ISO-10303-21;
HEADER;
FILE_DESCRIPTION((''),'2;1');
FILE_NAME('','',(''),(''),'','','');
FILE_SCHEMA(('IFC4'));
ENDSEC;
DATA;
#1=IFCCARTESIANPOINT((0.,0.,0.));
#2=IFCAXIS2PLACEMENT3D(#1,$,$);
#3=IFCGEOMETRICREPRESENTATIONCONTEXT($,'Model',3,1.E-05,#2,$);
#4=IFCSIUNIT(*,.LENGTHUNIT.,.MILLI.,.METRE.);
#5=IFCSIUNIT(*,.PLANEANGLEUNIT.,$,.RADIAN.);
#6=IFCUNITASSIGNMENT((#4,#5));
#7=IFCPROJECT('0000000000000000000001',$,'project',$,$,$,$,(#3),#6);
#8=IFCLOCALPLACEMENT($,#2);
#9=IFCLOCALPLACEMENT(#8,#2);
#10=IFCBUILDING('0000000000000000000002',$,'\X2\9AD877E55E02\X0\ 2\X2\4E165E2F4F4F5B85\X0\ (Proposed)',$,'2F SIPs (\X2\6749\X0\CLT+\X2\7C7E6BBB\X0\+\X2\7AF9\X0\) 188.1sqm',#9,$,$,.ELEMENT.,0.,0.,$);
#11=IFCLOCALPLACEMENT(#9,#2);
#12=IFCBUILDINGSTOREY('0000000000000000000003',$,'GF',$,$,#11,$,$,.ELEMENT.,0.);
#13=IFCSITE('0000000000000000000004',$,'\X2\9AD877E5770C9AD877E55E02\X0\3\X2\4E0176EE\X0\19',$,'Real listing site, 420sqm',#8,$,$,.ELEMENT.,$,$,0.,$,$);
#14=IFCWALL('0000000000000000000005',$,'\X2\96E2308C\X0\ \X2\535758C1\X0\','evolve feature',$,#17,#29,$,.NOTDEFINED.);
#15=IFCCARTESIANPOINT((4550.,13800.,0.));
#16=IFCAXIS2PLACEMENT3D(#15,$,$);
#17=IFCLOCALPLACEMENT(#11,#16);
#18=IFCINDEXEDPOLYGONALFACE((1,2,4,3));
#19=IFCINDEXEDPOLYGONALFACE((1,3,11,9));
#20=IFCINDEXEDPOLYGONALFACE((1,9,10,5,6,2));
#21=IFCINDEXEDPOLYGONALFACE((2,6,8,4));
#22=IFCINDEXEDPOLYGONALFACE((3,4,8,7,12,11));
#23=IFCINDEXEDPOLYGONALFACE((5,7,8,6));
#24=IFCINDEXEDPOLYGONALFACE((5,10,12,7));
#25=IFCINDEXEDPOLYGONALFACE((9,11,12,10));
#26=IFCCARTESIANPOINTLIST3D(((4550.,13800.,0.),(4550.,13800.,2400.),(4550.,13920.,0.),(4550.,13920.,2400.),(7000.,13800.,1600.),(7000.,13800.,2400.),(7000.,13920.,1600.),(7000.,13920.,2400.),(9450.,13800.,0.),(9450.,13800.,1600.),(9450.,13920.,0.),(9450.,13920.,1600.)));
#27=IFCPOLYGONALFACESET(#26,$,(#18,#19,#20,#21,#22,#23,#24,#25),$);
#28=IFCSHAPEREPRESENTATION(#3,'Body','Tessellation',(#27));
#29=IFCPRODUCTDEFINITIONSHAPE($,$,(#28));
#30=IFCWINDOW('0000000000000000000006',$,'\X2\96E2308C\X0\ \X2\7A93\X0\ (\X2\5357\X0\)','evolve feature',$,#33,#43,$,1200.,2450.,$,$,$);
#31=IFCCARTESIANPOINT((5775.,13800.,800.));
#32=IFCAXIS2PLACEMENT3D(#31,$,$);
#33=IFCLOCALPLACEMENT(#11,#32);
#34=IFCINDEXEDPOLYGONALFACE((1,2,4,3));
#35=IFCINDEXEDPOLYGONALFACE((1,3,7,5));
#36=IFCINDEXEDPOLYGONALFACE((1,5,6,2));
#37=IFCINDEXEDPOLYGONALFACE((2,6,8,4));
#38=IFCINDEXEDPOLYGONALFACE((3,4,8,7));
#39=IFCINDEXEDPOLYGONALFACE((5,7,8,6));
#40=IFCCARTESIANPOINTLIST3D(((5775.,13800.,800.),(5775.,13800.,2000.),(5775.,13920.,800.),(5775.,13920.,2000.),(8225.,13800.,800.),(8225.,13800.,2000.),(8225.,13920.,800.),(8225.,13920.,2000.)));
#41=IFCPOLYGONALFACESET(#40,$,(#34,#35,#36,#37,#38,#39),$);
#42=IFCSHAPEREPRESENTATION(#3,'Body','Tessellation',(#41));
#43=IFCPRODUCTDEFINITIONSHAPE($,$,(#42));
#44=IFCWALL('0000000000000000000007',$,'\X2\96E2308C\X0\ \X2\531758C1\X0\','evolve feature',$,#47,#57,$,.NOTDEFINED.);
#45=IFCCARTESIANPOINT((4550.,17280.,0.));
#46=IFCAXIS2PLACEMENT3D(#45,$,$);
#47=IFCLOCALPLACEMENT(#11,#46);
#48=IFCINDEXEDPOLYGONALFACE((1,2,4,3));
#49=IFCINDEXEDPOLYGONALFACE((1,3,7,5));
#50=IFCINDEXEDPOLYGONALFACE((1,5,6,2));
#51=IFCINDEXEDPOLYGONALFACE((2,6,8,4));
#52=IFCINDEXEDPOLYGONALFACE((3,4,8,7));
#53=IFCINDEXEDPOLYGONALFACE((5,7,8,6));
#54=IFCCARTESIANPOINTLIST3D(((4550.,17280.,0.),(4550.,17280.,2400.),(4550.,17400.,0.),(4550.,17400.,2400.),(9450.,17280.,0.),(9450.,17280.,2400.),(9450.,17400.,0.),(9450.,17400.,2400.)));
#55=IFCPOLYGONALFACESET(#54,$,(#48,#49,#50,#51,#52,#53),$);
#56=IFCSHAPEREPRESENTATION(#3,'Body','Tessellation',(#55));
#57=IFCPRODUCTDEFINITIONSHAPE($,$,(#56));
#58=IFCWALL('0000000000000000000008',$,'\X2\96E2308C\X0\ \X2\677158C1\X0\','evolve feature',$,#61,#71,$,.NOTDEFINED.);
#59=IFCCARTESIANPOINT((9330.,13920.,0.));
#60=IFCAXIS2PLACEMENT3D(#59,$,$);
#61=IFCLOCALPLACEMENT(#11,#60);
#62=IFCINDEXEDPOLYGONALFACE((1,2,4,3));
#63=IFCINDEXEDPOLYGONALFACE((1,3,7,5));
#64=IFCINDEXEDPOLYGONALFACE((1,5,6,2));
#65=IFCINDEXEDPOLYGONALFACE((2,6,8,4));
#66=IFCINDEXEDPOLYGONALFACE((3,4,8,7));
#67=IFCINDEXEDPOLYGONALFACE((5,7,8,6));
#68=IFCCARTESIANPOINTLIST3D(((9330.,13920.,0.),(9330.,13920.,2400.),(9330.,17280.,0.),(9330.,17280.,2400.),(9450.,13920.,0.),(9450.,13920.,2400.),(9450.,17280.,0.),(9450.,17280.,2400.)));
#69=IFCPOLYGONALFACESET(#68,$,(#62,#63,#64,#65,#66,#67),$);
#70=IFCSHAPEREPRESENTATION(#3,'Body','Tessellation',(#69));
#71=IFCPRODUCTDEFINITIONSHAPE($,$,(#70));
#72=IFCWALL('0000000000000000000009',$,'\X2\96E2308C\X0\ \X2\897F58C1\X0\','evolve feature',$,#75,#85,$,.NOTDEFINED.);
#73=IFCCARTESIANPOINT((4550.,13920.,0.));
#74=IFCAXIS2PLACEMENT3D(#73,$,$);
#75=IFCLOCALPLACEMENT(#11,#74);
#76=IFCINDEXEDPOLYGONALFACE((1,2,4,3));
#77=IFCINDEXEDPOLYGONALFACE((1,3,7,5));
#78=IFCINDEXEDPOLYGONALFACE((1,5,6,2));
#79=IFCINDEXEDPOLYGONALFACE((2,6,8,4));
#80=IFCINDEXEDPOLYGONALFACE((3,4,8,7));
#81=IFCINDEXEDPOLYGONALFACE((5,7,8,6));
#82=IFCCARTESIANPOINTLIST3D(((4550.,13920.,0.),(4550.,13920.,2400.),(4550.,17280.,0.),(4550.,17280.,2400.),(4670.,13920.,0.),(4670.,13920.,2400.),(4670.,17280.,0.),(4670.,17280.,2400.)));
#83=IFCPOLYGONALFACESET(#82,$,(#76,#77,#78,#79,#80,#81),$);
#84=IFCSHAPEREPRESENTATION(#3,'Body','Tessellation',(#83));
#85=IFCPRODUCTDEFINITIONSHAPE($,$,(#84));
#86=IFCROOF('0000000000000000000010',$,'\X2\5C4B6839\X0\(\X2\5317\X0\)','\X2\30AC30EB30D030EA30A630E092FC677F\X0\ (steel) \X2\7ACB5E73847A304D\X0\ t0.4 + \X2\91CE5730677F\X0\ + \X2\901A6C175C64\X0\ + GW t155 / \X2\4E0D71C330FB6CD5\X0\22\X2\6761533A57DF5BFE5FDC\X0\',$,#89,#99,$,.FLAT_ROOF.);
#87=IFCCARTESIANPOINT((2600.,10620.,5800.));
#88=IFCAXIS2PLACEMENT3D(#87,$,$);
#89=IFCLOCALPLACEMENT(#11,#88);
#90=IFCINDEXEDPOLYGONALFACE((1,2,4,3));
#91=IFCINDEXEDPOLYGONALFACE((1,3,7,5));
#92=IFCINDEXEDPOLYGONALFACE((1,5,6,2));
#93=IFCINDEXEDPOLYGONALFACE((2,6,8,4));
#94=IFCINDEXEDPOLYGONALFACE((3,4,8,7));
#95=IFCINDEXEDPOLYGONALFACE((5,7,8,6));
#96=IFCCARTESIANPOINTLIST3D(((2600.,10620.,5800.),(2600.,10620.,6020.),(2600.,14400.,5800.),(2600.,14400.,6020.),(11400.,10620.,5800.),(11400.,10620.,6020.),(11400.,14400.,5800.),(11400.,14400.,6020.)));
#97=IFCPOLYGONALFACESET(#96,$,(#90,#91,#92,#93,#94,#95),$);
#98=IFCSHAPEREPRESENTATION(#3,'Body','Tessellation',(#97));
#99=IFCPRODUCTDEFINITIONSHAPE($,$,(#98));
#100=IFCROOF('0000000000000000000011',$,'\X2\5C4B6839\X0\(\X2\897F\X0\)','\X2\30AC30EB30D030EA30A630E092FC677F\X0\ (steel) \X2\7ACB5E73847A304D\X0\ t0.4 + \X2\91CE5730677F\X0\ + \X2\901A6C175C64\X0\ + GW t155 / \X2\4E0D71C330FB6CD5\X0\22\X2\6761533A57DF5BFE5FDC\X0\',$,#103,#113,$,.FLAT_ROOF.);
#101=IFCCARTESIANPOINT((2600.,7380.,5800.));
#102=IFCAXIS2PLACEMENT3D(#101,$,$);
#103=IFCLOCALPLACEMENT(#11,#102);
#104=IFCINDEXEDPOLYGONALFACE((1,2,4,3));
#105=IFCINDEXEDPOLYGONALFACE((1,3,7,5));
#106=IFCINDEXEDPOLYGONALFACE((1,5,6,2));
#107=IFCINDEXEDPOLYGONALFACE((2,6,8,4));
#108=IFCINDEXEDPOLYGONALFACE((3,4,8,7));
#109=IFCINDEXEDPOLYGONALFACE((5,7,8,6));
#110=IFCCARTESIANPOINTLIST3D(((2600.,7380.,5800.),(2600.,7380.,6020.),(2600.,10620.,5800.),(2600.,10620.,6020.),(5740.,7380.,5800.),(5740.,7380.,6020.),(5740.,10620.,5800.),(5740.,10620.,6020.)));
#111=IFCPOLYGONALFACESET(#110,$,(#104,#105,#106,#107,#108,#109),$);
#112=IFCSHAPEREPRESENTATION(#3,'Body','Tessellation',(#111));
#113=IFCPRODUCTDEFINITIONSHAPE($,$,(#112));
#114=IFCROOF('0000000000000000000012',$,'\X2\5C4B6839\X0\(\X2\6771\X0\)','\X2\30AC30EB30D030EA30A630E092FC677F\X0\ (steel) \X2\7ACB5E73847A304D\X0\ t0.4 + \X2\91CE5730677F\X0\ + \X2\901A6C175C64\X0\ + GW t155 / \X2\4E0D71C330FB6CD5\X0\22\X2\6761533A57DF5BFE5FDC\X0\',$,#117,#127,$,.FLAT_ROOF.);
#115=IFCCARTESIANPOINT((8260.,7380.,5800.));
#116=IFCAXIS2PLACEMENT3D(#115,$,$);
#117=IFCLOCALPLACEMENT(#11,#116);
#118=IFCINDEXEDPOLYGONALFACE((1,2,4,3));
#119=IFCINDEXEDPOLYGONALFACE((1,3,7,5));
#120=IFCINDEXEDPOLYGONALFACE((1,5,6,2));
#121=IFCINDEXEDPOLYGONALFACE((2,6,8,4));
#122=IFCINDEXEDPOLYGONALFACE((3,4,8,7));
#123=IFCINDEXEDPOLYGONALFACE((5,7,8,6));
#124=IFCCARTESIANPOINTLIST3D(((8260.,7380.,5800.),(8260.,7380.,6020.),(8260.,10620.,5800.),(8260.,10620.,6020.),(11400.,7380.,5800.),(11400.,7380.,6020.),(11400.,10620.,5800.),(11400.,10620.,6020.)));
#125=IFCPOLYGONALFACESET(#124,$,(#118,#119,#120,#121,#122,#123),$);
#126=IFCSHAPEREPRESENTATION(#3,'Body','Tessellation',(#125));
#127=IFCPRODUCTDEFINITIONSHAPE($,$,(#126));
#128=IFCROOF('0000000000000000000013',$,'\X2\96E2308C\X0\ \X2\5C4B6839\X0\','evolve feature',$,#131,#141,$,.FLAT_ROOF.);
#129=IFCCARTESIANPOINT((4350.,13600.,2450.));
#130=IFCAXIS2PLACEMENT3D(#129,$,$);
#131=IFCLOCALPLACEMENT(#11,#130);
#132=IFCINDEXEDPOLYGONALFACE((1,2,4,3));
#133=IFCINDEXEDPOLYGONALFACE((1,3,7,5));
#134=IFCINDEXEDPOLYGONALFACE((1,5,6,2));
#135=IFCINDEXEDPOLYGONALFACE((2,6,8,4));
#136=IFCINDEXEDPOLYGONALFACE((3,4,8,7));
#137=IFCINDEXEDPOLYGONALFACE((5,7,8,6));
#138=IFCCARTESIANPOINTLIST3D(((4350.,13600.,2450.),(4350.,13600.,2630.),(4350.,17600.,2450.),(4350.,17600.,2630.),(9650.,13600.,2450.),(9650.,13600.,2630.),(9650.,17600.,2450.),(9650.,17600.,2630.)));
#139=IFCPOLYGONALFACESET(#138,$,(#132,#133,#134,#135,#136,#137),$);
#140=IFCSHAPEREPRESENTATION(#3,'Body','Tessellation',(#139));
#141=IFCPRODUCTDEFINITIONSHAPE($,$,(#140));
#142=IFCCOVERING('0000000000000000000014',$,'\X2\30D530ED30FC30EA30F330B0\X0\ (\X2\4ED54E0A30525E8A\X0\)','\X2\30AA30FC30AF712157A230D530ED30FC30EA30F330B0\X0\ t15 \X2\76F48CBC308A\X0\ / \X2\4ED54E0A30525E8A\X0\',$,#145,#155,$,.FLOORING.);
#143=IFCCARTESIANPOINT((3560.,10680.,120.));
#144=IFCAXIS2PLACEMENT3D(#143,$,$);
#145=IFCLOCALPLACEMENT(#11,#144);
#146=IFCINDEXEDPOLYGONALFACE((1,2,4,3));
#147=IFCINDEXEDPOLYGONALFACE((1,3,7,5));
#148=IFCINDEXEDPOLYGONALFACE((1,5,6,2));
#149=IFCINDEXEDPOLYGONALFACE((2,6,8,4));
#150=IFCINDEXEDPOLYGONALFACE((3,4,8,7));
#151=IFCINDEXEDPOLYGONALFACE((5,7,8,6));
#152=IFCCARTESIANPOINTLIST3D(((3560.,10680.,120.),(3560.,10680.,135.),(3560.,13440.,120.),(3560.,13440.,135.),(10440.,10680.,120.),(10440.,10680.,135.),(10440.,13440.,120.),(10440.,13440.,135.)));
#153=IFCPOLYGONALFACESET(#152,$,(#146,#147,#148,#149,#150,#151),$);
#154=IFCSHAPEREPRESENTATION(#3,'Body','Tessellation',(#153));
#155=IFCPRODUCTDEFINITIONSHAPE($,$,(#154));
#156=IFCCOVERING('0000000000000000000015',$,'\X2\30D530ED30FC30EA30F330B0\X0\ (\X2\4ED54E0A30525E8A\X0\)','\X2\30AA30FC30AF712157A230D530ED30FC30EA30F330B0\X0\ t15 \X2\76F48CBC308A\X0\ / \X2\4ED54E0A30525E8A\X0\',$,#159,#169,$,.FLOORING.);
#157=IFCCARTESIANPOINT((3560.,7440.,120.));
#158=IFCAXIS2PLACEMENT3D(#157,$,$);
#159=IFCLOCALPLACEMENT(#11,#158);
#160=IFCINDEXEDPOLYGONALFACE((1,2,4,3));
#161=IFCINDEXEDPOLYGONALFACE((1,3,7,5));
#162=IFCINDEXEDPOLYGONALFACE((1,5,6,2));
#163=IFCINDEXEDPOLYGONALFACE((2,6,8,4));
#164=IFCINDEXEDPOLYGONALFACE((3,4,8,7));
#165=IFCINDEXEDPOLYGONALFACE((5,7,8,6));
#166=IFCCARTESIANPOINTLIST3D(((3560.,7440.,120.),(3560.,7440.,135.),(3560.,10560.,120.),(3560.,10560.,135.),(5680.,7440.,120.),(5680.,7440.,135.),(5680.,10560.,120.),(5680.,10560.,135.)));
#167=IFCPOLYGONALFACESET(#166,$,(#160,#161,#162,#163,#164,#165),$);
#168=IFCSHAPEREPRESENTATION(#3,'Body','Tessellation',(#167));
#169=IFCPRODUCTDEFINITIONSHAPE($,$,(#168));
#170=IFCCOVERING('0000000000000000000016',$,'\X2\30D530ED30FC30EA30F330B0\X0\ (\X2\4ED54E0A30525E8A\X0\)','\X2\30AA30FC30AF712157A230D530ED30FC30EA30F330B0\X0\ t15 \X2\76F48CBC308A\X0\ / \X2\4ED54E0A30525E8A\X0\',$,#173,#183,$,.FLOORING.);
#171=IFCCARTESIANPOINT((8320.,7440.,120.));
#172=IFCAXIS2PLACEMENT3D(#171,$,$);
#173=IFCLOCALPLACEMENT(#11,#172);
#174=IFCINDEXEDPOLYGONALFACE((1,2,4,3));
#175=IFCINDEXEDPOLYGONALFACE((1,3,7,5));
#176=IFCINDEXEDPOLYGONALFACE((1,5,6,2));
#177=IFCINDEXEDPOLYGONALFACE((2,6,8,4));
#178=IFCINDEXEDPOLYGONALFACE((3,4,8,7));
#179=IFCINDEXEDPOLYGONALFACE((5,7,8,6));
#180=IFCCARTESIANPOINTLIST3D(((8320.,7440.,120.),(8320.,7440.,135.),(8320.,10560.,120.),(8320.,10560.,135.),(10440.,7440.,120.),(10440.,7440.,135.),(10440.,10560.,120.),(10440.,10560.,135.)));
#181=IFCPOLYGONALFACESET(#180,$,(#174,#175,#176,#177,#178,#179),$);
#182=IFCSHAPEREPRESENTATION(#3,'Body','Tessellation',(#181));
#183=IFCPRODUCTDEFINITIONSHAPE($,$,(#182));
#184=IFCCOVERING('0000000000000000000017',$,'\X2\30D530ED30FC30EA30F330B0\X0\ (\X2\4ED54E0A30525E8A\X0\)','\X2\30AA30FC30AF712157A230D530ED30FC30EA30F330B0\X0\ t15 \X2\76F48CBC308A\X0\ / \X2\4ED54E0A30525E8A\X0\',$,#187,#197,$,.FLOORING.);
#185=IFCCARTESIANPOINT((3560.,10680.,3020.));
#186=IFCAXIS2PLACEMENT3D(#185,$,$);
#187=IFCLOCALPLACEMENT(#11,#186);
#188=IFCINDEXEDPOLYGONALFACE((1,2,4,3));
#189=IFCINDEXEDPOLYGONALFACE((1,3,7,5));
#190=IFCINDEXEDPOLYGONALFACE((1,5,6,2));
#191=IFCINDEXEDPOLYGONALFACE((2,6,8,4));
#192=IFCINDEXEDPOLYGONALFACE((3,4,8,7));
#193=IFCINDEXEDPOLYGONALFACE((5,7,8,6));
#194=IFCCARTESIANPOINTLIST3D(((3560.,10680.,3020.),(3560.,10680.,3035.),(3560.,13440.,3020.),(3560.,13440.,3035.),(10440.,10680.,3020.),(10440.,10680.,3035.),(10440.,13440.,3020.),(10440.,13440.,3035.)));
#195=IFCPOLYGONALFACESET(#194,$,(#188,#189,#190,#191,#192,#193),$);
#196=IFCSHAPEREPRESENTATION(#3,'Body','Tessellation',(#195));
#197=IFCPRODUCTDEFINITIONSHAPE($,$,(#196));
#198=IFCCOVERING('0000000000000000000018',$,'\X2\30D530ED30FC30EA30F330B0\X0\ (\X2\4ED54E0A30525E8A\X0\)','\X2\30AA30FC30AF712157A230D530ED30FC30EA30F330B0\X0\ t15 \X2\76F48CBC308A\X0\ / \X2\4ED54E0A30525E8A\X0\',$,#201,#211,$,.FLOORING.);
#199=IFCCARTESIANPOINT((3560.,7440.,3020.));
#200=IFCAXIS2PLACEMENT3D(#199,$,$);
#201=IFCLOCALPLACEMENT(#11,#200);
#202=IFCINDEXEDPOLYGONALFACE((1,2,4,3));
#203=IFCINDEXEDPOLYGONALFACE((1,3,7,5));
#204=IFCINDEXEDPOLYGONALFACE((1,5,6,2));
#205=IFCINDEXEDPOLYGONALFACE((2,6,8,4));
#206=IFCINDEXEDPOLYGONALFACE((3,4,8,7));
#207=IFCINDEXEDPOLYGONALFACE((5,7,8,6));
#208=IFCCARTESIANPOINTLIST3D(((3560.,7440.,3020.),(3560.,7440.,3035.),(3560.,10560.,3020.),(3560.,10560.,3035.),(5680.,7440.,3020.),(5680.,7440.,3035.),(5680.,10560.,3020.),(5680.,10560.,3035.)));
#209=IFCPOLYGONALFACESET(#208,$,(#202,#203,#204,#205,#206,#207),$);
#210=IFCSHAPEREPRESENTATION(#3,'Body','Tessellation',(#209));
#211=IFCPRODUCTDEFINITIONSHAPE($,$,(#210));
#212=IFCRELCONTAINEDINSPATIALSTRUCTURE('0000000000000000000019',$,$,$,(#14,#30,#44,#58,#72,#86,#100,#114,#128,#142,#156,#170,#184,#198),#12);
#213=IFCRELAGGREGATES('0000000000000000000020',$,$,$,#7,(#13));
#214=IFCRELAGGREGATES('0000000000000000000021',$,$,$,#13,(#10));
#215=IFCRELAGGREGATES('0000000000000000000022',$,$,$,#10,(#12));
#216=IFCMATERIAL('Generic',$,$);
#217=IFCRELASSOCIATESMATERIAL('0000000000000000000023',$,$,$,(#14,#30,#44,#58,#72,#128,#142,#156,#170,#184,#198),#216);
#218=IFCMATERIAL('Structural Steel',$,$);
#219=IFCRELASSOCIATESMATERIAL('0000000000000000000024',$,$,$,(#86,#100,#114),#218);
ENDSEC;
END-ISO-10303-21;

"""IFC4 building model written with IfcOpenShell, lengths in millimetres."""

from ifc_helpers import new_model, si_unit, frame, frame_2d, origin, place, context, project, spatial, rectangle, extrude, material, element, fill, save


model = new_model("IFC4")

# Units and contexts
model_context = context("Model", 3, precision=1e-05, world=origin())
ifc_project = project(units=[si_unit("LENGTHUNIT", "METRE", prefix="MILLI"), si_unit("PLANEANGLEUNIT", "RADIAN")], contexts=[model_context])

# Site, building, storey
site_placement = place(None, origin())
site = spatial("IfcSite", under=ifc_project, at=site_placement, Name="高知県高知市3丁目19", ObjectType="Real listing site, 420sqm", CompositionType="ELEMENT", RefElevation=0.0)
building_placement = place(site_placement, origin())
building = spatial("IfcBuilding", under=site, at=building_placement, Name="高知市 2世帯住宅 (Proposed)", ObjectType="2F SIPs (杉CLT+籾殻+竹) 188.1sqm", CompositionType="ELEMENT", ElevationOfRefHeight=0.0, ElevationOfTerrain=0.0)
storey_placement = place(building_placement, origin())
storey = spatial("IfcBuildingStorey", under=building, at=storey_placement, Name="GF", CompositionType="ELEMENT", Elevation=0.0)

# Shared definitions
ifc_material_1 = material(Name="Generic")

# Wall, opening, window
wall_1_placement = place(storey_placement, frame((4550.0, 13800.0, 0.0)))
wall_1 = element("IfcWall", 1, at=wall_1_placement, inside=storey, material=ifc_material_1, Name="離れ 南壁", Description="evolve feature", PredefinedType="NOTDEFINED", context=model_context, shape_type="SweptSolid", body=[
    extrude(rectangle(XDim=4900.0, YDim=120.0, at=frame_2d((2450.0, 60.0))), frame((4550.0, 13800.0, 0.0)), (0.0, 0.0, 1.0), 2400.0),
])
opening_1_placement = place(storey_placement, frame((5775.0, 13800.0, 800.0)))
opening_1 = element("IfcOpeningElement", 2, at=opening_1_placement, cuts=wall_1, PredefinedType="NOTDEFINED", context=model_context, shape_type="SweptSolid", body=[
    extrude(rectangle(XDim=2450.0, YDim=120.0, at=frame_2d((1225.0, 60.0))), frame((5775.0, 13800.0, 800.0)), (0.0, 0.0, 1.0), 1200.0),
])
window_1_placement = place(storey_placement, frame((5775.0, 13800.0, 800.0)))
window_1 = element("IfcWindow", 3, at=window_1_placement, inside=storey, material=ifc_material_1, Name="離れ 窓 (南)", Description="evolve feature", OverallHeight=1200.0, OverallWidth=2450.0, context=model_context, shape_type="SweptSolid", body=[
    extrude(rectangle(XDim=2450.0, YDim=120.0, at=frame_2d((1225.0, 60.0))), frame((5775.0, 13800.0, 800.0)), (0.0, 0.0, 1.0), 1200.0),
])
fill(opening_1, window_1)

# Walls
wall_2_placement = place(storey_placement, frame((4550.0, 17280.0, 0.0)))
element("IfcWall", 4, at=wall_2_placement, inside=storey, material=ifc_material_1, Name="離れ 北壁", Description="evolve feature", PredefinedType="NOTDEFINED", context=model_context, shape_type="SweptSolid", body=[
    extrude(rectangle(XDim=4900.0, YDim=120.0, at=frame_2d((2450.0, 60.0))), frame((4550.0, 17280.0, 0.0)), (0.0, 0.0, 1.0), 2400.0),
])
wall_3_placement = place(storey_placement, frame((9330.0, 13920.0, 0.0)))
element("IfcWall", 5, at=wall_3_placement, inside=storey, material=ifc_material_1, Name="離れ 東壁", Description="evolve feature", PredefinedType="NOTDEFINED", context=model_context, shape_type="SweptSolid", body=[
    extrude(rectangle(XDim=120.0, YDim=3360.0, at=frame_2d((60.0, 1680.0))), frame((9330.0, 13920.0, 0.0)), (0.0, 0.0, 1.0), 2400.0),
])
wall_4_placement = place(storey_placement, frame((4550.0, 13920.0, 0.0)))
element("IfcWall", 6, at=wall_4_placement, inside=storey, material=ifc_material_1, Name="離れ 西壁", Description="evolve feature", PredefinedType="NOTDEFINED", context=model_context, shape_type="SweptSolid", body=[
    extrude(rectangle(XDim=120.0, YDim=3360.0, at=frame_2d((60.0, 1680.0))), frame((4550.0, 13920.0, 0.0)), (0.0, 0.0, 1.0), 2400.0),
])

# Roofs
ifc_material_2 = material(Name="Structural Steel")
for number, where, name in (
    (7, (2600.0, 10620.0, 5800.0), "屋根(北)"),
):
    element("IfcRoof", number, at=place(storey_placement, frame(where)), inside=storey, material=ifc_material_2, Name=name, Description="ガルバリウム鋼板 (steel) 立平葺き t0.4 + 野地板 + 通気層 + GW t155 / 不燃・法22条区域対応", PredefinedType="FLAT_ROOF", context=model_context, shape_type="SweptSolid", body=[
        extrude(rectangle(XDim=8800.0, YDim=3780.0, at=frame_2d((4400.0, 1890.0))), frame((2600.0, 10620.0, 5800.0)), (0.0, 0.0, 1.0), 220.0),
    ])
roof_1_placement = place(storey_placement, frame((2600.0, 7380.0, 5800.0)))
element("IfcRoof", 8, at=roof_1_placement, inside=storey, material=ifc_material_2, Name="屋根(西)", Description="ガルバリウム鋼板 (steel) 立平葺き t0.4 + 野地板 + 通気層 + GW t155 / 不燃・法22条区域対応", PredefinedType="FLAT_ROOF", context=model_context, shape_type="SweptSolid", body=[
    extrude(rectangle(XDim=3140.0, YDim=3240.0, at=frame_2d((1570.0, 1620.0))), frame((2600.0, 7380.0, 5800.0)), (0.0, 0.0, 1.0), 220.0),
])
roof_2_placement = place(storey_placement, frame((8260.0, 7380.0, 5800.0)))
element("IfcRoof", 9, at=roof_2_placement, inside=storey, material=ifc_material_2, Name="屋根(東)", Description="ガルバリウム鋼板 (steel) 立平葺き t0.4 + 野地板 + 通気層 + GW t155 / 不燃・法22条区域対応", PredefinedType="FLAT_ROOF", context=model_context, shape_type="SweptSolid", body=[
    extrude(rectangle(XDim=3140.0, YDim=3240.0, at=frame_2d((1570.0, 1620.0))), frame((8260.0, 7380.0, 5800.0)), (0.0, 0.0, 1.0), 220.0),
])
roof_3_placement = place(storey_placement, frame((4350.0, 13600.0, 2450.0)))
element("IfcRoof", 10, at=roof_3_placement, inside=storey, material=ifc_material_1, Name="離れ 屋根", Description="evolve feature", PredefinedType="FLAT_ROOF", context=model_context, shape_type="SweptSolid", body=[
    extrude(rectangle(XDim=5300.0, YDim=4000.0, at=frame_2d((2650.0, 2000.0))), frame((4350.0, 13600.0, 2450.0)), (0.0, 0.0, 1.0), 180.0),
])

# Coverings
covering_1_placement = place(storey_placement, frame((3560.0, 10680.0, 120.0)))
element("IfcCovering", 11, at=covering_1_placement, inside=storey, material=ifc_material_1, Name="フローリング (仕上げ床)", Description="オーク無垢フローリング t15 直貼り / 仕上げ床", PredefinedType="FLOORING", context=model_context, shape_type="SweptSolid", body=[
    extrude(rectangle(XDim=6880.0, YDim=2760.0, at=frame_2d((3440.0, 1380.0))), frame((3560.0, 10680.0, 120.0)), (0.0, 0.0, 1.0), 15.0),
])
covering_2_placement = place(storey_placement, frame((3560.0, 7440.0, 120.0)))
element("IfcCovering", 12, at=covering_2_placement, inside=storey, material=ifc_material_1, Name="フローリング (仕上げ床)", Description="オーク無垢フローリング t15 直貼り / 仕上げ床", PredefinedType="FLOORING", context=model_context, shape_type="SweptSolid", body=[
    extrude(rectangle(XDim=2120.0, YDim=3120.0, at=frame_2d((1060.0, 1560.0))), frame((3560.0, 7440.0, 120.0)), (0.0, 0.0, 1.0), 15.0),
])
covering_3_placement = place(storey_placement, frame((8320.0, 7440.0, 120.0)))
element("IfcCovering", 13, at=covering_3_placement, inside=storey, material=ifc_material_1, Name="フローリング (仕上げ床)", Description="オーク無垢フローリング t15 直貼り / 仕上げ床", PredefinedType="FLOORING", context=model_context, shape_type="SweptSolid", body=[
    extrude(rectangle(XDim=2120.0, YDim=3120.0, at=frame_2d((1060.0, 1560.0))), frame((8320.0, 7440.0, 120.0)), (0.0, 0.0, 1.0), 15.0),
])
covering_4_placement = place(storey_placement, frame((3560.0, 10680.0, 3020.0)))
element("IfcCovering", 14, at=covering_4_placement, inside=storey, material=ifc_material_1, Name="フローリング (仕上げ床)", Description="オーク無垢フローリング t15 直貼り / 仕上げ床", PredefinedType="FLOORING", context=model_context, shape_type="SweptSolid", body=[
    extrude(rectangle(XDim=6880.0, YDim=2760.0, at=frame_2d((3440.0, 1380.0))), frame((3560.0, 10680.0, 3020.0)), (0.0, 0.0, 1.0), 15.0),
])
covering_5_placement = place(storey_placement, frame((3560.0, 7440.0, 3020.0)))
element("IfcCovering", 15, at=covering_5_placement, inside=storey, material=ifc_material_1, Name="フローリング (仕上げ床)", Description="オーク無垢フローリング t15 直貼り / 仕上げ床", PredefinedType="FLOORING", context=model_context, shape_type="SweptSolid", body=[
    extrude(rectangle(XDim=2120.0, YDim=3120.0, at=frame_2d((1060.0, 1560.0))), frame((3560.0, 7440.0, 3020.0)), (0.0, 0.0, 1.0), 15.0),
])

save(model, "model.ifc")
